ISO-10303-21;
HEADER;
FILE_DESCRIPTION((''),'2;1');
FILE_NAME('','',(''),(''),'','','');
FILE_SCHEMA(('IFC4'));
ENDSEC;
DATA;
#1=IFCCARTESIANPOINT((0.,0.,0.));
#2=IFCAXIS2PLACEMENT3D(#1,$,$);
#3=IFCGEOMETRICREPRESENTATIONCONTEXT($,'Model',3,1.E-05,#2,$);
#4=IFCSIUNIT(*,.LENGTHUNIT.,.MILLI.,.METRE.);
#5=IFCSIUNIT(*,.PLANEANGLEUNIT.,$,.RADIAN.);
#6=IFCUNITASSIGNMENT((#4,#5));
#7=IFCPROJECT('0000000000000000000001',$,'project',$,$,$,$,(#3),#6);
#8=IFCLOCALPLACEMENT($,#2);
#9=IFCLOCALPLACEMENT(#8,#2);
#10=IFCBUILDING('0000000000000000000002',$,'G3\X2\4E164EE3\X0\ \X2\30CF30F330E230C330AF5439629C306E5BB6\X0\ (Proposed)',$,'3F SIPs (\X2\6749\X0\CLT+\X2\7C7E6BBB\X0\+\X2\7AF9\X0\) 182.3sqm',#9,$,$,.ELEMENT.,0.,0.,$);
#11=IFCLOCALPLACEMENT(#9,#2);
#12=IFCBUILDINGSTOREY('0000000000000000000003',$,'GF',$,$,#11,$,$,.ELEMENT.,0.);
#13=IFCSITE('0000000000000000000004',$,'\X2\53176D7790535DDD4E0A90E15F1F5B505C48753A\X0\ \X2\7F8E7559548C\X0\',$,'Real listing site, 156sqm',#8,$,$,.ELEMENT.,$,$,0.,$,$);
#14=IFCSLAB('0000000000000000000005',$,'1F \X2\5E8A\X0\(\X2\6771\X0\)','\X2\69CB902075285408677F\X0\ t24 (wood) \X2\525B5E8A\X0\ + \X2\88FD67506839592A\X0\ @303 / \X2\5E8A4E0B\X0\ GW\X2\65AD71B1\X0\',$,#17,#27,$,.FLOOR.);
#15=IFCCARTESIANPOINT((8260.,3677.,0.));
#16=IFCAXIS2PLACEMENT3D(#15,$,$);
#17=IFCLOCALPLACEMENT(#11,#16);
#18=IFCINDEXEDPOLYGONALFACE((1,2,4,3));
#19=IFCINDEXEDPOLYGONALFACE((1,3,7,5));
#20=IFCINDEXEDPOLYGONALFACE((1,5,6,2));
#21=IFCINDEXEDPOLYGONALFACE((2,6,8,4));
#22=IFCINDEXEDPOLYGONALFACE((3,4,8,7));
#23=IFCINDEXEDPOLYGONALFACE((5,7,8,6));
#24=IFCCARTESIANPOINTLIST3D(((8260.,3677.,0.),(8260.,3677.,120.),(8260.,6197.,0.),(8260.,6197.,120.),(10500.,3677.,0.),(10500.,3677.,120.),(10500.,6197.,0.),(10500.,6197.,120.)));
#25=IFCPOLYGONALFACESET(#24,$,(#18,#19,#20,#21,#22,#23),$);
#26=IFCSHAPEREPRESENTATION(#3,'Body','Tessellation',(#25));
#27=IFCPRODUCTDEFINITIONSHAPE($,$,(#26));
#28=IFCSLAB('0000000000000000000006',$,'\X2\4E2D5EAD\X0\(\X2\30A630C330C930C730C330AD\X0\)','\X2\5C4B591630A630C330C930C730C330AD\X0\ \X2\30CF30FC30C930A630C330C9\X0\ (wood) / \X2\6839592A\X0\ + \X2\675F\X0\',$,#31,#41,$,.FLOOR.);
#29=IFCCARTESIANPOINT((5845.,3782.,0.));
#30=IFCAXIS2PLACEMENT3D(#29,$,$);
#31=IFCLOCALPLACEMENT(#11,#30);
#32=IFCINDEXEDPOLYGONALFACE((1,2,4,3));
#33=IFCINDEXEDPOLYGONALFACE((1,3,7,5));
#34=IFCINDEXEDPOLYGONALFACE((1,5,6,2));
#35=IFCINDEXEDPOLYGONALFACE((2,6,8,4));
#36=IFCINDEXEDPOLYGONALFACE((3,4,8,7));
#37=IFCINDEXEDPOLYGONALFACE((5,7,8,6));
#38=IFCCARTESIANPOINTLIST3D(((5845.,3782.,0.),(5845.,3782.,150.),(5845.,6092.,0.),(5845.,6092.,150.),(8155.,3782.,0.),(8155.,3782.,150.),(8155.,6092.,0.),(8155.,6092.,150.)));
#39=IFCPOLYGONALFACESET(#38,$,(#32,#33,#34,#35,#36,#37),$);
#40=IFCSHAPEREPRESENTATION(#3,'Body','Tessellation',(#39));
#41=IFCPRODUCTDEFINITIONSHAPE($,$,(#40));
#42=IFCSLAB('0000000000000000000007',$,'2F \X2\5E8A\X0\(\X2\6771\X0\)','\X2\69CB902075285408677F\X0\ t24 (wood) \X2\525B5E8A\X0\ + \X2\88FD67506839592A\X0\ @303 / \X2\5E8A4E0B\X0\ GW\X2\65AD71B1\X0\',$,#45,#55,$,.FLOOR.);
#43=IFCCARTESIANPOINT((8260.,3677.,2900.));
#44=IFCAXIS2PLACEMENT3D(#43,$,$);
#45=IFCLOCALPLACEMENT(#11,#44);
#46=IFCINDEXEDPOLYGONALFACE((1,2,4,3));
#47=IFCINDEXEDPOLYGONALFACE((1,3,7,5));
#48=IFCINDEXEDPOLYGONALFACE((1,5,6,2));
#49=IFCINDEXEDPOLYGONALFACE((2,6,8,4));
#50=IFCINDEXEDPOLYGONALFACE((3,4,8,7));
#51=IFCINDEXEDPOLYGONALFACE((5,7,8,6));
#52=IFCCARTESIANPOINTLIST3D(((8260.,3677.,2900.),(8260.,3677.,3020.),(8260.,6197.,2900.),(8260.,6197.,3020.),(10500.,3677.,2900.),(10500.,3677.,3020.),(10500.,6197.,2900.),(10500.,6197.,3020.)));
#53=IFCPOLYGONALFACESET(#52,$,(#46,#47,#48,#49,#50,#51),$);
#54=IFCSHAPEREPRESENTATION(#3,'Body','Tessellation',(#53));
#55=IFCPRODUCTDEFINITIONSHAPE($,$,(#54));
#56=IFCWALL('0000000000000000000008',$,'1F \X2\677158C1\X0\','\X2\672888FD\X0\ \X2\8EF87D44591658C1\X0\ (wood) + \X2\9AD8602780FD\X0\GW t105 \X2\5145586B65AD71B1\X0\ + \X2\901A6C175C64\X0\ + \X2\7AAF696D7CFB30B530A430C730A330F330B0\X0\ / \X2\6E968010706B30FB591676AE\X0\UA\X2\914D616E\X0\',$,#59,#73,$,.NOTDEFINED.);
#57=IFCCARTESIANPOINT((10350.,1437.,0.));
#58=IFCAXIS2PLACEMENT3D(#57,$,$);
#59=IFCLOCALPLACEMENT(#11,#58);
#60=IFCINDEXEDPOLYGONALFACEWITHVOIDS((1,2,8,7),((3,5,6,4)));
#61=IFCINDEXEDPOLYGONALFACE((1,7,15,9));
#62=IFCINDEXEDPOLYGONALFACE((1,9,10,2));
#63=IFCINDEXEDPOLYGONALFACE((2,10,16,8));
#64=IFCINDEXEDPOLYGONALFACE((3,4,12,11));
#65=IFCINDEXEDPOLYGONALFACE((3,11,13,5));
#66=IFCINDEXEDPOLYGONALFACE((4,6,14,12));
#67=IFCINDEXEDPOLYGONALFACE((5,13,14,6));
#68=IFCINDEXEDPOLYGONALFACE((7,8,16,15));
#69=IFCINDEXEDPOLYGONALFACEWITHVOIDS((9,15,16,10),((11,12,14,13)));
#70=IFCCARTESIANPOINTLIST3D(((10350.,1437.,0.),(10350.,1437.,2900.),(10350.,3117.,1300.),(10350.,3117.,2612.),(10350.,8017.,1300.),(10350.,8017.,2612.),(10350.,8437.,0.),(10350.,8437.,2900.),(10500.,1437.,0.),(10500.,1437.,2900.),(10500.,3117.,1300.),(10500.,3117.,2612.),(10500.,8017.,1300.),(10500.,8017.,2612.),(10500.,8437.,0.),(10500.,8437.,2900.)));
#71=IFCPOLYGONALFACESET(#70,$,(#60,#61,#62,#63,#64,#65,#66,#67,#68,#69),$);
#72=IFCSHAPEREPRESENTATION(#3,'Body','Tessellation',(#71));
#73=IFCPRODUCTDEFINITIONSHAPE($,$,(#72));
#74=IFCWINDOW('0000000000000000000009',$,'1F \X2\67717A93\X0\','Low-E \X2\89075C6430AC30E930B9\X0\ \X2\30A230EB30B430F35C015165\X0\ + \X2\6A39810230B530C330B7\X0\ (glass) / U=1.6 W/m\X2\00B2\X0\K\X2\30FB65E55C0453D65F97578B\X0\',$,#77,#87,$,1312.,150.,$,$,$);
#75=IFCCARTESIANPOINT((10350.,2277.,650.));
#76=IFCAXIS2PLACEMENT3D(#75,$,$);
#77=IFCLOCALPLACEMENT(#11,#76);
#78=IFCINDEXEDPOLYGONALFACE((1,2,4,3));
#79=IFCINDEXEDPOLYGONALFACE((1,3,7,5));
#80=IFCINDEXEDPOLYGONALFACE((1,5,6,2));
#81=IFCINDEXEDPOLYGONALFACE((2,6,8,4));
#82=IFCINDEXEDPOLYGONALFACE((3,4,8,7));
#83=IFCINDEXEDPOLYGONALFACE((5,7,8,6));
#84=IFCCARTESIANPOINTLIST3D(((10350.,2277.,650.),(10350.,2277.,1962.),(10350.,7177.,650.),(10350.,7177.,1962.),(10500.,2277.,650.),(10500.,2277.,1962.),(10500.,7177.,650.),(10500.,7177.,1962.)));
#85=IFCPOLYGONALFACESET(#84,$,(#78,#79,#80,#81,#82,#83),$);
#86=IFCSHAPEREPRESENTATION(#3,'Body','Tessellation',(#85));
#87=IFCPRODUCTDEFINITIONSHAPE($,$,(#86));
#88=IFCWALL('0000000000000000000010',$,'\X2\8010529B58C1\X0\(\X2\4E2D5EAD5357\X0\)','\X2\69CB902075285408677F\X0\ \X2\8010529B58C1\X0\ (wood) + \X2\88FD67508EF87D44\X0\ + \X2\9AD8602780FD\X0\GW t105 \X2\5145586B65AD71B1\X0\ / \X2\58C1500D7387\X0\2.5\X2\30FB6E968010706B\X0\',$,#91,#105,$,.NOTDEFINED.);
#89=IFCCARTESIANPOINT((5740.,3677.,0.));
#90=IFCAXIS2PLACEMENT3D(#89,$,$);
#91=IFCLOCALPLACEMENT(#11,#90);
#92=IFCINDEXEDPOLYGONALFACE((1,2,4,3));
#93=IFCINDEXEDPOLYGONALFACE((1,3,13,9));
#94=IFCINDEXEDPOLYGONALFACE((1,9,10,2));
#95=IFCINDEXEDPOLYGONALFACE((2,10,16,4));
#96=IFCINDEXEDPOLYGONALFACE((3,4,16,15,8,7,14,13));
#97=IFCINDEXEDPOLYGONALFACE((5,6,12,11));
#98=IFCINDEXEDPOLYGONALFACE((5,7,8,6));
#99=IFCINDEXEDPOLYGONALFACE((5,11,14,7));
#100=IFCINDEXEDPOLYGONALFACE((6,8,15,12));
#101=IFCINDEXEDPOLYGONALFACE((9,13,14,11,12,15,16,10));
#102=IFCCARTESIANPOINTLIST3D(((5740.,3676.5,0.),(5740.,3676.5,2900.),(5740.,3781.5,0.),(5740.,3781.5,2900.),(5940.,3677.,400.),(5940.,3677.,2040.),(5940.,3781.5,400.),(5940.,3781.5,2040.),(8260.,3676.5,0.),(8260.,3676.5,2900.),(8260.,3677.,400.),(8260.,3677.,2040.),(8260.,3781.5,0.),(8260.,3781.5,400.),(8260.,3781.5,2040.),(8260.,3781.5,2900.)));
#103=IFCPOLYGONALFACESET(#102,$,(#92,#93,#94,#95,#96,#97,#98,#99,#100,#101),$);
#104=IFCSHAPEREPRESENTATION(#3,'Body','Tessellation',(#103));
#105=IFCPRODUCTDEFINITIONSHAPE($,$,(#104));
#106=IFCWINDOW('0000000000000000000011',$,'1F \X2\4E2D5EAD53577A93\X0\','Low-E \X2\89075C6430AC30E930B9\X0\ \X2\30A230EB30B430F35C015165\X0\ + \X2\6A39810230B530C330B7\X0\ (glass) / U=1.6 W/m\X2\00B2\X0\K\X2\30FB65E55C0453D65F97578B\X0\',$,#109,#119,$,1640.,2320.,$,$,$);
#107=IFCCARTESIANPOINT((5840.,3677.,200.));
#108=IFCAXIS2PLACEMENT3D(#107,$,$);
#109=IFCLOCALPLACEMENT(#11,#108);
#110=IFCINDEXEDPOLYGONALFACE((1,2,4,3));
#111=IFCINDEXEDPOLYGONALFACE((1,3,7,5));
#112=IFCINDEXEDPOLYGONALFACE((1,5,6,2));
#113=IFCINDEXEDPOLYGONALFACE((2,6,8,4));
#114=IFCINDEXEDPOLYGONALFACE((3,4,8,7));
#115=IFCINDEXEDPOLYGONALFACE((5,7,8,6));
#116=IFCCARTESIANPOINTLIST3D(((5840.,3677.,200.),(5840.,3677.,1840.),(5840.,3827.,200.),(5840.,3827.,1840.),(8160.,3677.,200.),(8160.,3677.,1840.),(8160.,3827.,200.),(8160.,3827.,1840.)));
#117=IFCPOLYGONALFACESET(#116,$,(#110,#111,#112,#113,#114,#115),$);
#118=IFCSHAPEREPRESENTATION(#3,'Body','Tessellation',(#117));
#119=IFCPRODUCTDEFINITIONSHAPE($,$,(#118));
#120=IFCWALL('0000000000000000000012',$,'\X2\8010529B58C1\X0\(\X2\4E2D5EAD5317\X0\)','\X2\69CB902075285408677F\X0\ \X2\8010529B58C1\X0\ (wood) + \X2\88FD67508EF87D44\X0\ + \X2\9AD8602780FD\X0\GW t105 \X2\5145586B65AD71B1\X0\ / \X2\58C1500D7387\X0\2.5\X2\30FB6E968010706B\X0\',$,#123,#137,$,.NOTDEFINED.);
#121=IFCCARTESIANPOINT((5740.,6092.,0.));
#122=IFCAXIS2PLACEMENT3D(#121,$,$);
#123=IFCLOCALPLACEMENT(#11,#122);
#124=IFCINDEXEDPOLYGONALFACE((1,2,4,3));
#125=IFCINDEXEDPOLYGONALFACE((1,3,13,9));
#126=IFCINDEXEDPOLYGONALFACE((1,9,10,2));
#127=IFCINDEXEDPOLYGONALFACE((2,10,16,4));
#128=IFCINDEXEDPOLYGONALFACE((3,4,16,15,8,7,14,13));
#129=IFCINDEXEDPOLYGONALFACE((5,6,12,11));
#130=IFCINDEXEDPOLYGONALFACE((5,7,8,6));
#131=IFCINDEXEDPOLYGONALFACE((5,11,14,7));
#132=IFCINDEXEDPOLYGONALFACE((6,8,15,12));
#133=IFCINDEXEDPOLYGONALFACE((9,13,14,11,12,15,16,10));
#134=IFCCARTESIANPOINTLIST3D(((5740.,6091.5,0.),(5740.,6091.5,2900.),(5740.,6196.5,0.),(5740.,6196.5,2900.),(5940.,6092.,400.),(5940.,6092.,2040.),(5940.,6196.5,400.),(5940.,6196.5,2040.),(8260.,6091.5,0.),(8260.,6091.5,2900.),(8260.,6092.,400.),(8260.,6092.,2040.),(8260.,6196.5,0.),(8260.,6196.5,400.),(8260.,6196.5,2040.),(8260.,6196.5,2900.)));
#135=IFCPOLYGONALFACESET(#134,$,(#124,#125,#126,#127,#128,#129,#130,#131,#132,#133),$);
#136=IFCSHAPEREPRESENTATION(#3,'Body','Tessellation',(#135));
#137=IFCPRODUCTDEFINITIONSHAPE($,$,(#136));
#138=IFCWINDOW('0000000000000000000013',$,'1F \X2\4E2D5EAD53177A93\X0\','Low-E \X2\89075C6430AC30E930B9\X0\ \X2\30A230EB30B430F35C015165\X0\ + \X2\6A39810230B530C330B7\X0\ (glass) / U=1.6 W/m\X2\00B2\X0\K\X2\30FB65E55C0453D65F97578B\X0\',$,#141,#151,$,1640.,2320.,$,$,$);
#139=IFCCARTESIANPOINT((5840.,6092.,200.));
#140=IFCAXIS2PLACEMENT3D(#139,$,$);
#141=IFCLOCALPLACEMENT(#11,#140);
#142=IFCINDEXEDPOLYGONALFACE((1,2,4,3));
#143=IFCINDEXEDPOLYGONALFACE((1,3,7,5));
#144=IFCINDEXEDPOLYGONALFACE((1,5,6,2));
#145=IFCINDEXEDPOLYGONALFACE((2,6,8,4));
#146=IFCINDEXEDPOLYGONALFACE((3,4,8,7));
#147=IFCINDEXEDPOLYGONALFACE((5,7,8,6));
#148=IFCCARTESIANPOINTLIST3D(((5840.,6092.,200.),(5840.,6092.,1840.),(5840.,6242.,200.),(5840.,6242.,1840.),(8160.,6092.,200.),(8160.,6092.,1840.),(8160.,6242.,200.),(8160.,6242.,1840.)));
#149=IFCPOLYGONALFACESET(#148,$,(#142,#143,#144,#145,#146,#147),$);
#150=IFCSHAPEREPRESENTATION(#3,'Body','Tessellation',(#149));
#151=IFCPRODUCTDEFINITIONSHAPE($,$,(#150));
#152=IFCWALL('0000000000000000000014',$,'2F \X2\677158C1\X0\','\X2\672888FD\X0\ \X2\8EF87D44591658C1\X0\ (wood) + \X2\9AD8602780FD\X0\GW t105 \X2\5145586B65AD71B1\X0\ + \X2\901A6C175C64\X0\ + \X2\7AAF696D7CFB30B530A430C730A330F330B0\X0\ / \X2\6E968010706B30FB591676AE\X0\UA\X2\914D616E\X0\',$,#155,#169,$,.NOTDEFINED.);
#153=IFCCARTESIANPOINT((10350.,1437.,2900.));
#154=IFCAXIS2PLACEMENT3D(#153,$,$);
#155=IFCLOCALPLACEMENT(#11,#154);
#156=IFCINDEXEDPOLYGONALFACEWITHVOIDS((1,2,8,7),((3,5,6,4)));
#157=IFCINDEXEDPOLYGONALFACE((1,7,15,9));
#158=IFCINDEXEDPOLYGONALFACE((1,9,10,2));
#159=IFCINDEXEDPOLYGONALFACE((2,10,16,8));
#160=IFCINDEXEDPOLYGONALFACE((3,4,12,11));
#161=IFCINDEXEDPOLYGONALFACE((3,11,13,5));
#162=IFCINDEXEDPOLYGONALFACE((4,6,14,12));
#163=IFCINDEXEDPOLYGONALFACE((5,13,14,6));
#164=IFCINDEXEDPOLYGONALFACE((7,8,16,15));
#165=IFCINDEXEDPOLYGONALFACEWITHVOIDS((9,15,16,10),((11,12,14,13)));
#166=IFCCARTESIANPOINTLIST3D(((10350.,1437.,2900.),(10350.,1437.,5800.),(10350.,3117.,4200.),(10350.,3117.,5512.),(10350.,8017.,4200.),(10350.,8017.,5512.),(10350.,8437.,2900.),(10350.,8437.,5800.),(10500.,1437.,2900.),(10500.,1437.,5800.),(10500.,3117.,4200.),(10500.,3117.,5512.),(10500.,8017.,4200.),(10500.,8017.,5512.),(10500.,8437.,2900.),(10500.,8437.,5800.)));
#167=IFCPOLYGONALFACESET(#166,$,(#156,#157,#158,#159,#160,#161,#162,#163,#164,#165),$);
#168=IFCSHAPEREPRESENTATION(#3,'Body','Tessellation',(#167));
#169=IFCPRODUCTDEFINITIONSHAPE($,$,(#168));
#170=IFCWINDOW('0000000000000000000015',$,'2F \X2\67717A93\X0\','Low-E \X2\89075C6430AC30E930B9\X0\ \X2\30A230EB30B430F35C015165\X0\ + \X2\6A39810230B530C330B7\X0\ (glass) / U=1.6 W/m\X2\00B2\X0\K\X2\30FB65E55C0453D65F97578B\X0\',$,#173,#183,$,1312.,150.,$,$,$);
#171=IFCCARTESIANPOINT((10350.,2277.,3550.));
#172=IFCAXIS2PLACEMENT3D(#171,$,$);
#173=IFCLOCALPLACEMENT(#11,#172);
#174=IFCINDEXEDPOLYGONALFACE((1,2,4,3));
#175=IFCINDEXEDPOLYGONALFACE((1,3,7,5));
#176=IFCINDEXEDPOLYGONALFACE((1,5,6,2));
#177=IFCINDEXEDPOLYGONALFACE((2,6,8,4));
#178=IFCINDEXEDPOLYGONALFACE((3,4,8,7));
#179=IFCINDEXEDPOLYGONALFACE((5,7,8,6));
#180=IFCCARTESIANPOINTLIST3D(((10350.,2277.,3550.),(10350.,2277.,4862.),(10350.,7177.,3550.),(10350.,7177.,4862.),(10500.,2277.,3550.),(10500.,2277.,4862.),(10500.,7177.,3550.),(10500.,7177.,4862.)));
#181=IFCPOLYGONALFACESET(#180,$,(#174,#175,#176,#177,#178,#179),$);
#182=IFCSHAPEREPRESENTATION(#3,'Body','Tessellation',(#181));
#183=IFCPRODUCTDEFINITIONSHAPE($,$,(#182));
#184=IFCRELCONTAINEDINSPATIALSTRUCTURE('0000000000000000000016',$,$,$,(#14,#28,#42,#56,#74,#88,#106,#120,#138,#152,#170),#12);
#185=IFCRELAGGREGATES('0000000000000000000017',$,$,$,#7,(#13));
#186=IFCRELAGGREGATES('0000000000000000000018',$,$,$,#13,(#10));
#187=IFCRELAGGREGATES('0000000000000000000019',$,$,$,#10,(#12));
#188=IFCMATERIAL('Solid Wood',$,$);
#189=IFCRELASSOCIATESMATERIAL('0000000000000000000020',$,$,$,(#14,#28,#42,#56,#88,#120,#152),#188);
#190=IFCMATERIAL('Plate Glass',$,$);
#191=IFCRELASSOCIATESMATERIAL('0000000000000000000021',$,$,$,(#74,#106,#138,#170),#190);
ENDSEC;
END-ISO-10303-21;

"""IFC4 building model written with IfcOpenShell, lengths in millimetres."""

from ifc_helpers import new_model, si_unit, frame, frame_2d, origin, place, context, project, spatial, rectangle, extrude, material, element, fill, save


model = new_model("IFC4")

# Units and contexts
model_context = context("Model", 3, precision=1e-05, world=origin())
ifc_project = project(units=[si_unit("LENGTHUNIT", "METRE", prefix="MILLI"), si_unit("PLANEANGLEUNIT", "RADIAN")], contexts=[model_context])

# Site, building, storey
site_placement = place(None, origin())
site = spatial("IfcSite", under=ifc_project, at=site_placement, Name="北海道川上郡弟子屈町 美留和", ObjectType="Real listing site, 156sqm", CompositionType="ELEMENT", RefElevation=0.0)
building_placement = place(site_placement, origin())
building = spatial("IfcBuilding", under=site, at=building_placement, Name="G3世代 ハンモック吹抜の家 (Proposed)", ObjectType="3F SIPs (杉CLT+籾殻+竹) 182.3sqm", CompositionType="ELEMENT", ElevationOfRefHeight=0.0, ElevationOfTerrain=0.0)
storey_placement = place(building_placement, origin())
storey = spatial("IfcBuildingStorey", under=building, at=storey_placement, Name="GF", CompositionType="ELEMENT", Elevation=0.0)

# Slabs
ifc_material_1 = material(Name="Solid Wood")
slab_1_placement = place(storey_placement, frame((8260.0, 3677.0, 0.0)))
element("IfcSlab", 1, at=slab_1_placement, inside=storey, material=ifc_material_1, Name="1F 床(東)", Description="構造用合板 t24 (wood) 剛床 + 製材根太 @303 / 床下 GW断熱", PredefinedType="FLOOR", context=model_context, shape_type="SweptSolid", body=[
    extrude(rectangle(XDim=2240.0, YDim=2520.0, at=frame_2d((1120.0, 1260.0))), frame((8260.0, 3677.0, 0.0)), (0.0, 0.0, 1.0), 120.0),
])
slab_2_placement = place(storey_placement, frame((5845.0, 3782.0, 0.0)))
element("IfcSlab", 2, at=slab_2_placement, inside=storey, material=ifc_material_1, Name="中庭(ウッドデッキ)", Description="屋外ウッドデッキ ハードウッド (wood) / 根太 + 束", PredefinedType="FLOOR", context=model_context, shape_type="SweptSolid", body=[
    extrude(rectangle(XDim=2310.0, YDim=2310.0, at=frame_2d((1155.0, 1155.0))), frame((5845.0, 3782.0, 0.0)), (0.0, 0.0, 1.0), 150.0),
])
slab_3_placement = place(storey_placement, frame((8260.0, 3677.0, 2900.0)))
element("IfcSlab", 3, at=slab_3_placement, inside=storey, material=ifc_material_1, Name="2F 床(東)", Description="構造用合板 t24 (wood) 剛床 + 製材根太 @303 / 床下 GW断熱", PredefinedType="FLOOR", context=model_context, shape_type="SweptSolid", body=[
    extrude(rectangle(XDim=2240.0, YDim=2520.0, at=frame_2d((1120.0, 1260.0))), frame((8260.0, 3677.0, 2900.0)), (0.0, 0.0, 1.0), 120.0),
])

# Walls, openings, windows
wall_1_placement = place(storey_placement, frame((10350.0, 1437.0, 0.0)))
wall_1 = element("IfcWall", 4, at=wall_1_placement, inside=storey, material=ifc_material_1, Name="1F 東壁", Description="木製 軸組外壁 (wood) + 高性能GW t105 充填断熱 + 通気層 + 窯業系サイディング / 準耐火・外皮UA配慮", PredefinedType="NOTDEFINED", context=model_context, shape_type="SweptSolid", body=[
    extrude(rectangle(XDim=150.0, YDim=7000.0, at=frame_2d((75.0, 3500.0))), frame((10350.0, 1437.0, 0.0)), (0.0, 0.0, 1.0), 2900.0),
])
opening_1_placement = place(storey_placement, frame((10350.0, 2277.0, 650.0)))
opening_1 = element("IfcOpeningElement", 5, at=opening_1_placement, cuts=wall_1, PredefinedType="NOTDEFINED", context=model_context, shape_type="SweptSolid", body=[
    extrude(rectangle(XDim=150.0, YDim=4900.0, at=frame_2d((75.0, 2450.0))), frame((10350.0, 2277.0, 650.0)), (0.0, 0.0, 1.0), 1312.0),
])
ifc_material_2 = material(Name="Plate Glass")
window_1_placement = place(storey_placement, frame((10350.0, 2277.0, 650.0)))
window_1 = element("IfcWindow", 6, at=window_1_placement, inside=storey, material=ifc_material_2, Name="1F 東窓", Description="Low-E 複層ガラス アルゴン封入 + 樹脂サッシ (glass) / U=1.6 W/m²K・日射取得型", OverallHeight=1312.0, OverallWidth=150.0, context=model_context, shape_type="SweptSolid", body=[
    extrude(rectangle(XDim=150.0, YDim=4900.0, at=frame_2d((75.0, 2450.0))), frame((10350.0, 2277.0, 650.0)), (0.0, 0.0, 1.0), 1312.0),
])
fill(opening_1, window_1)
wall_2_placement = place(storey_placement, frame((5740.0, 3677.0, 0.0)))
wall_2 = element("IfcWall", 7, at=wall_2_placement, inside=storey, material=ifc_material_1, Name="耐力壁(中庭南)", Description="構造用合板 耐力壁 (wood) + 製材軸組 + 高性能GW t105 充填断熱 / 壁倍率2.5・準耐火", PredefinedType="NOTDEFINED", context=model_context, shape_type="SweptSolid", body=[
    extrude(rectangle(XDim=2520.0, YDim=105.0, at=frame_2d((1260.0, 52.0))), frame((5740.0, 3677.0, 0.0)), (0.0, 0.0, 1.0), 2900.0),
])
opening_2_placement = place(storey_placement, frame((5840.0, 3677.0, 200.0)))
opening_2 = element("IfcOpeningElement", 8, at=opening_2_placement, cuts=wall_2, PredefinedType="NOTDEFINED", context=model_context, shape_type="SweptSolid", body=[
    extrude(rectangle(XDim=2320.0, YDim=150.0, at=frame_2d((1160.0, 75.0))), frame((5840.0, 3677.0, 200.0)), (0.0, 0.0, 1.0), 1640.0),
])
window_2_placement = place(storey_placement, frame((5840.0, 3677.0, 200.0)))
window_2 = element("IfcWindow", 9, at=window_2_placement, inside=storey, material=ifc_material_2, Name="1F 中庭南窓", Description="Low-E 複層ガラス アルゴン封入 + 樹脂サッシ (glass) / U=1.6 W/m²K・日射取得型", OverallHeight=1640.0, OverallWidth=2320.0, context=model_context, shape_type="SweptSolid", body=[
    extrude(rectangle(XDim=2320.0, YDim=150.0, at=frame_2d((1160.0, 75.0))), frame((5840.0, 3677.0, 200.0)), (0.0, 0.0, 1.0), 1640.0),
])
fill(opening_2, window_2)
wall_3_placement = place(storey_placement, frame((5740.0, 6092.0, 0.0)))
wall_3 = element("IfcWall", 10, at=wall_3_placement, inside=storey, material=ifc_material_1, Name="耐力壁(中庭北)", Description="構造用合板 耐力壁 (wood) + 製材軸組 + 高性能GW t105 充填断熱 / 壁倍率2.5・準耐火", PredefinedType="NOTDEFINED", context=model_context, shape_type="SweptSolid", body=[
    extrude(rectangle(XDim=2520.0, YDim=105.0, at=frame_2d((1260.0, 52.0))), frame((5740.0, 6092.0, 0.0)), (0.0, 0.0, 1.0), 2900.0),
])
opening_3_placement = place(storey_placement, frame((5840.0, 6092.0, 200.0)))
opening_3 = element("IfcOpeningElement", 11, at=opening_3_placement, cuts=wall_3, PredefinedType="NOTDEFINED", context=model_context, shape_type="SweptSolid", body=[
    extrude(rectangle(XDim=2320.0, YDim=150.0, at=frame_2d((1160.0, 75.0))), frame((5840.0, 6092.0, 200.0)), (0.0, 0.0, 1.0), 1640.0),
])
window_3_placement = place(storey_placement, frame((5840.0, 6092.0, 200.0)))
window_3 = element("IfcWindow", 12, at=window_3_placement, inside=storey, material=ifc_material_2, Name="1F 中庭北窓", Description="Low-E 複層ガラス アルゴン封入 + 樹脂サッシ (glass) / U=1.6 W/m²K・日射取得型", OverallHeight=1640.0, OverallWidth=2320.0, context=model_context, shape_type="SweptSolid", body=[
    extrude(rectangle(XDim=2320.0, YDim=150.0, at=frame_2d((1160.0, 75.0))), frame((5840.0, 6092.0, 200.0)), (0.0, 0.0, 1.0), 1640.0),
])
fill(opening_3, window_3)

# Wall, opening, window
wall_4_placement = place(storey_placement, frame((10350.0, 1437.0, 2900.0)))
wall_4 = element("IfcWall", 13, at=wall_4_placement, inside=storey, material=ifc_material_1, Name="2F 東壁", Description="木製 軸組外壁 (wood) + 高性能GW t105 充填断熱 + 通気層 + 窯業系サイディング / 準耐火・外皮UA配慮", PredefinedType="NOTDEFINED", context=model_context, shape_type="SweptSolid", body=[
    extrude(rectangle(XDim=150.0, YDim=7000.0, at=frame_2d((75.0, 3500.0))), frame((10350.0, 1437.0, 2900.0)), (0.0, 0.0, 1.0), 2900.0),
])
opening_4_placement = place(storey_placement, frame((10350.0, 2277.0, 3550.0)))
opening_4 = element("IfcOpeningElement", 14, at=opening_4_placement, cuts=wall_4, PredefinedType="NOTDEFINED", context=model_context, shape_type="SweptSolid", body=[
    extrude(rectangle(XDim=150.0, YDim=4900.0, at=frame_2d((75.0, 2450.0))), frame((10350.0, 2277.0, 3550.0)), (0.0, 0.0, 1.0), 1312.0),
])
window_4_placement = place(storey_placement, frame((10350.0, 2277.0, 3550.0)))
window_4 = element("IfcWindow", 15, at=window_4_placement, inside=storey, material=ifc_material_2, Name="2F 東窓", Description="Low-E 複層ガラス アルゴン封入 + 樹脂サッシ (glass) / U=1.6 W/m²K・日射取得型", OverallHeight=1312.0, OverallWidth=150.0, context=model_context, shape_type="SweptSolid", body=[
    extrude(rectangle(XDim=150.0, YDim=4900.0, at=frame_2d((75.0, 2450.0))), frame((10350.0, 2277.0, 3550.0)), (0.0, 0.0, 1.0), 1312.0),
])
fill(opening_4, window_4)

save(model, "model.ifc")
